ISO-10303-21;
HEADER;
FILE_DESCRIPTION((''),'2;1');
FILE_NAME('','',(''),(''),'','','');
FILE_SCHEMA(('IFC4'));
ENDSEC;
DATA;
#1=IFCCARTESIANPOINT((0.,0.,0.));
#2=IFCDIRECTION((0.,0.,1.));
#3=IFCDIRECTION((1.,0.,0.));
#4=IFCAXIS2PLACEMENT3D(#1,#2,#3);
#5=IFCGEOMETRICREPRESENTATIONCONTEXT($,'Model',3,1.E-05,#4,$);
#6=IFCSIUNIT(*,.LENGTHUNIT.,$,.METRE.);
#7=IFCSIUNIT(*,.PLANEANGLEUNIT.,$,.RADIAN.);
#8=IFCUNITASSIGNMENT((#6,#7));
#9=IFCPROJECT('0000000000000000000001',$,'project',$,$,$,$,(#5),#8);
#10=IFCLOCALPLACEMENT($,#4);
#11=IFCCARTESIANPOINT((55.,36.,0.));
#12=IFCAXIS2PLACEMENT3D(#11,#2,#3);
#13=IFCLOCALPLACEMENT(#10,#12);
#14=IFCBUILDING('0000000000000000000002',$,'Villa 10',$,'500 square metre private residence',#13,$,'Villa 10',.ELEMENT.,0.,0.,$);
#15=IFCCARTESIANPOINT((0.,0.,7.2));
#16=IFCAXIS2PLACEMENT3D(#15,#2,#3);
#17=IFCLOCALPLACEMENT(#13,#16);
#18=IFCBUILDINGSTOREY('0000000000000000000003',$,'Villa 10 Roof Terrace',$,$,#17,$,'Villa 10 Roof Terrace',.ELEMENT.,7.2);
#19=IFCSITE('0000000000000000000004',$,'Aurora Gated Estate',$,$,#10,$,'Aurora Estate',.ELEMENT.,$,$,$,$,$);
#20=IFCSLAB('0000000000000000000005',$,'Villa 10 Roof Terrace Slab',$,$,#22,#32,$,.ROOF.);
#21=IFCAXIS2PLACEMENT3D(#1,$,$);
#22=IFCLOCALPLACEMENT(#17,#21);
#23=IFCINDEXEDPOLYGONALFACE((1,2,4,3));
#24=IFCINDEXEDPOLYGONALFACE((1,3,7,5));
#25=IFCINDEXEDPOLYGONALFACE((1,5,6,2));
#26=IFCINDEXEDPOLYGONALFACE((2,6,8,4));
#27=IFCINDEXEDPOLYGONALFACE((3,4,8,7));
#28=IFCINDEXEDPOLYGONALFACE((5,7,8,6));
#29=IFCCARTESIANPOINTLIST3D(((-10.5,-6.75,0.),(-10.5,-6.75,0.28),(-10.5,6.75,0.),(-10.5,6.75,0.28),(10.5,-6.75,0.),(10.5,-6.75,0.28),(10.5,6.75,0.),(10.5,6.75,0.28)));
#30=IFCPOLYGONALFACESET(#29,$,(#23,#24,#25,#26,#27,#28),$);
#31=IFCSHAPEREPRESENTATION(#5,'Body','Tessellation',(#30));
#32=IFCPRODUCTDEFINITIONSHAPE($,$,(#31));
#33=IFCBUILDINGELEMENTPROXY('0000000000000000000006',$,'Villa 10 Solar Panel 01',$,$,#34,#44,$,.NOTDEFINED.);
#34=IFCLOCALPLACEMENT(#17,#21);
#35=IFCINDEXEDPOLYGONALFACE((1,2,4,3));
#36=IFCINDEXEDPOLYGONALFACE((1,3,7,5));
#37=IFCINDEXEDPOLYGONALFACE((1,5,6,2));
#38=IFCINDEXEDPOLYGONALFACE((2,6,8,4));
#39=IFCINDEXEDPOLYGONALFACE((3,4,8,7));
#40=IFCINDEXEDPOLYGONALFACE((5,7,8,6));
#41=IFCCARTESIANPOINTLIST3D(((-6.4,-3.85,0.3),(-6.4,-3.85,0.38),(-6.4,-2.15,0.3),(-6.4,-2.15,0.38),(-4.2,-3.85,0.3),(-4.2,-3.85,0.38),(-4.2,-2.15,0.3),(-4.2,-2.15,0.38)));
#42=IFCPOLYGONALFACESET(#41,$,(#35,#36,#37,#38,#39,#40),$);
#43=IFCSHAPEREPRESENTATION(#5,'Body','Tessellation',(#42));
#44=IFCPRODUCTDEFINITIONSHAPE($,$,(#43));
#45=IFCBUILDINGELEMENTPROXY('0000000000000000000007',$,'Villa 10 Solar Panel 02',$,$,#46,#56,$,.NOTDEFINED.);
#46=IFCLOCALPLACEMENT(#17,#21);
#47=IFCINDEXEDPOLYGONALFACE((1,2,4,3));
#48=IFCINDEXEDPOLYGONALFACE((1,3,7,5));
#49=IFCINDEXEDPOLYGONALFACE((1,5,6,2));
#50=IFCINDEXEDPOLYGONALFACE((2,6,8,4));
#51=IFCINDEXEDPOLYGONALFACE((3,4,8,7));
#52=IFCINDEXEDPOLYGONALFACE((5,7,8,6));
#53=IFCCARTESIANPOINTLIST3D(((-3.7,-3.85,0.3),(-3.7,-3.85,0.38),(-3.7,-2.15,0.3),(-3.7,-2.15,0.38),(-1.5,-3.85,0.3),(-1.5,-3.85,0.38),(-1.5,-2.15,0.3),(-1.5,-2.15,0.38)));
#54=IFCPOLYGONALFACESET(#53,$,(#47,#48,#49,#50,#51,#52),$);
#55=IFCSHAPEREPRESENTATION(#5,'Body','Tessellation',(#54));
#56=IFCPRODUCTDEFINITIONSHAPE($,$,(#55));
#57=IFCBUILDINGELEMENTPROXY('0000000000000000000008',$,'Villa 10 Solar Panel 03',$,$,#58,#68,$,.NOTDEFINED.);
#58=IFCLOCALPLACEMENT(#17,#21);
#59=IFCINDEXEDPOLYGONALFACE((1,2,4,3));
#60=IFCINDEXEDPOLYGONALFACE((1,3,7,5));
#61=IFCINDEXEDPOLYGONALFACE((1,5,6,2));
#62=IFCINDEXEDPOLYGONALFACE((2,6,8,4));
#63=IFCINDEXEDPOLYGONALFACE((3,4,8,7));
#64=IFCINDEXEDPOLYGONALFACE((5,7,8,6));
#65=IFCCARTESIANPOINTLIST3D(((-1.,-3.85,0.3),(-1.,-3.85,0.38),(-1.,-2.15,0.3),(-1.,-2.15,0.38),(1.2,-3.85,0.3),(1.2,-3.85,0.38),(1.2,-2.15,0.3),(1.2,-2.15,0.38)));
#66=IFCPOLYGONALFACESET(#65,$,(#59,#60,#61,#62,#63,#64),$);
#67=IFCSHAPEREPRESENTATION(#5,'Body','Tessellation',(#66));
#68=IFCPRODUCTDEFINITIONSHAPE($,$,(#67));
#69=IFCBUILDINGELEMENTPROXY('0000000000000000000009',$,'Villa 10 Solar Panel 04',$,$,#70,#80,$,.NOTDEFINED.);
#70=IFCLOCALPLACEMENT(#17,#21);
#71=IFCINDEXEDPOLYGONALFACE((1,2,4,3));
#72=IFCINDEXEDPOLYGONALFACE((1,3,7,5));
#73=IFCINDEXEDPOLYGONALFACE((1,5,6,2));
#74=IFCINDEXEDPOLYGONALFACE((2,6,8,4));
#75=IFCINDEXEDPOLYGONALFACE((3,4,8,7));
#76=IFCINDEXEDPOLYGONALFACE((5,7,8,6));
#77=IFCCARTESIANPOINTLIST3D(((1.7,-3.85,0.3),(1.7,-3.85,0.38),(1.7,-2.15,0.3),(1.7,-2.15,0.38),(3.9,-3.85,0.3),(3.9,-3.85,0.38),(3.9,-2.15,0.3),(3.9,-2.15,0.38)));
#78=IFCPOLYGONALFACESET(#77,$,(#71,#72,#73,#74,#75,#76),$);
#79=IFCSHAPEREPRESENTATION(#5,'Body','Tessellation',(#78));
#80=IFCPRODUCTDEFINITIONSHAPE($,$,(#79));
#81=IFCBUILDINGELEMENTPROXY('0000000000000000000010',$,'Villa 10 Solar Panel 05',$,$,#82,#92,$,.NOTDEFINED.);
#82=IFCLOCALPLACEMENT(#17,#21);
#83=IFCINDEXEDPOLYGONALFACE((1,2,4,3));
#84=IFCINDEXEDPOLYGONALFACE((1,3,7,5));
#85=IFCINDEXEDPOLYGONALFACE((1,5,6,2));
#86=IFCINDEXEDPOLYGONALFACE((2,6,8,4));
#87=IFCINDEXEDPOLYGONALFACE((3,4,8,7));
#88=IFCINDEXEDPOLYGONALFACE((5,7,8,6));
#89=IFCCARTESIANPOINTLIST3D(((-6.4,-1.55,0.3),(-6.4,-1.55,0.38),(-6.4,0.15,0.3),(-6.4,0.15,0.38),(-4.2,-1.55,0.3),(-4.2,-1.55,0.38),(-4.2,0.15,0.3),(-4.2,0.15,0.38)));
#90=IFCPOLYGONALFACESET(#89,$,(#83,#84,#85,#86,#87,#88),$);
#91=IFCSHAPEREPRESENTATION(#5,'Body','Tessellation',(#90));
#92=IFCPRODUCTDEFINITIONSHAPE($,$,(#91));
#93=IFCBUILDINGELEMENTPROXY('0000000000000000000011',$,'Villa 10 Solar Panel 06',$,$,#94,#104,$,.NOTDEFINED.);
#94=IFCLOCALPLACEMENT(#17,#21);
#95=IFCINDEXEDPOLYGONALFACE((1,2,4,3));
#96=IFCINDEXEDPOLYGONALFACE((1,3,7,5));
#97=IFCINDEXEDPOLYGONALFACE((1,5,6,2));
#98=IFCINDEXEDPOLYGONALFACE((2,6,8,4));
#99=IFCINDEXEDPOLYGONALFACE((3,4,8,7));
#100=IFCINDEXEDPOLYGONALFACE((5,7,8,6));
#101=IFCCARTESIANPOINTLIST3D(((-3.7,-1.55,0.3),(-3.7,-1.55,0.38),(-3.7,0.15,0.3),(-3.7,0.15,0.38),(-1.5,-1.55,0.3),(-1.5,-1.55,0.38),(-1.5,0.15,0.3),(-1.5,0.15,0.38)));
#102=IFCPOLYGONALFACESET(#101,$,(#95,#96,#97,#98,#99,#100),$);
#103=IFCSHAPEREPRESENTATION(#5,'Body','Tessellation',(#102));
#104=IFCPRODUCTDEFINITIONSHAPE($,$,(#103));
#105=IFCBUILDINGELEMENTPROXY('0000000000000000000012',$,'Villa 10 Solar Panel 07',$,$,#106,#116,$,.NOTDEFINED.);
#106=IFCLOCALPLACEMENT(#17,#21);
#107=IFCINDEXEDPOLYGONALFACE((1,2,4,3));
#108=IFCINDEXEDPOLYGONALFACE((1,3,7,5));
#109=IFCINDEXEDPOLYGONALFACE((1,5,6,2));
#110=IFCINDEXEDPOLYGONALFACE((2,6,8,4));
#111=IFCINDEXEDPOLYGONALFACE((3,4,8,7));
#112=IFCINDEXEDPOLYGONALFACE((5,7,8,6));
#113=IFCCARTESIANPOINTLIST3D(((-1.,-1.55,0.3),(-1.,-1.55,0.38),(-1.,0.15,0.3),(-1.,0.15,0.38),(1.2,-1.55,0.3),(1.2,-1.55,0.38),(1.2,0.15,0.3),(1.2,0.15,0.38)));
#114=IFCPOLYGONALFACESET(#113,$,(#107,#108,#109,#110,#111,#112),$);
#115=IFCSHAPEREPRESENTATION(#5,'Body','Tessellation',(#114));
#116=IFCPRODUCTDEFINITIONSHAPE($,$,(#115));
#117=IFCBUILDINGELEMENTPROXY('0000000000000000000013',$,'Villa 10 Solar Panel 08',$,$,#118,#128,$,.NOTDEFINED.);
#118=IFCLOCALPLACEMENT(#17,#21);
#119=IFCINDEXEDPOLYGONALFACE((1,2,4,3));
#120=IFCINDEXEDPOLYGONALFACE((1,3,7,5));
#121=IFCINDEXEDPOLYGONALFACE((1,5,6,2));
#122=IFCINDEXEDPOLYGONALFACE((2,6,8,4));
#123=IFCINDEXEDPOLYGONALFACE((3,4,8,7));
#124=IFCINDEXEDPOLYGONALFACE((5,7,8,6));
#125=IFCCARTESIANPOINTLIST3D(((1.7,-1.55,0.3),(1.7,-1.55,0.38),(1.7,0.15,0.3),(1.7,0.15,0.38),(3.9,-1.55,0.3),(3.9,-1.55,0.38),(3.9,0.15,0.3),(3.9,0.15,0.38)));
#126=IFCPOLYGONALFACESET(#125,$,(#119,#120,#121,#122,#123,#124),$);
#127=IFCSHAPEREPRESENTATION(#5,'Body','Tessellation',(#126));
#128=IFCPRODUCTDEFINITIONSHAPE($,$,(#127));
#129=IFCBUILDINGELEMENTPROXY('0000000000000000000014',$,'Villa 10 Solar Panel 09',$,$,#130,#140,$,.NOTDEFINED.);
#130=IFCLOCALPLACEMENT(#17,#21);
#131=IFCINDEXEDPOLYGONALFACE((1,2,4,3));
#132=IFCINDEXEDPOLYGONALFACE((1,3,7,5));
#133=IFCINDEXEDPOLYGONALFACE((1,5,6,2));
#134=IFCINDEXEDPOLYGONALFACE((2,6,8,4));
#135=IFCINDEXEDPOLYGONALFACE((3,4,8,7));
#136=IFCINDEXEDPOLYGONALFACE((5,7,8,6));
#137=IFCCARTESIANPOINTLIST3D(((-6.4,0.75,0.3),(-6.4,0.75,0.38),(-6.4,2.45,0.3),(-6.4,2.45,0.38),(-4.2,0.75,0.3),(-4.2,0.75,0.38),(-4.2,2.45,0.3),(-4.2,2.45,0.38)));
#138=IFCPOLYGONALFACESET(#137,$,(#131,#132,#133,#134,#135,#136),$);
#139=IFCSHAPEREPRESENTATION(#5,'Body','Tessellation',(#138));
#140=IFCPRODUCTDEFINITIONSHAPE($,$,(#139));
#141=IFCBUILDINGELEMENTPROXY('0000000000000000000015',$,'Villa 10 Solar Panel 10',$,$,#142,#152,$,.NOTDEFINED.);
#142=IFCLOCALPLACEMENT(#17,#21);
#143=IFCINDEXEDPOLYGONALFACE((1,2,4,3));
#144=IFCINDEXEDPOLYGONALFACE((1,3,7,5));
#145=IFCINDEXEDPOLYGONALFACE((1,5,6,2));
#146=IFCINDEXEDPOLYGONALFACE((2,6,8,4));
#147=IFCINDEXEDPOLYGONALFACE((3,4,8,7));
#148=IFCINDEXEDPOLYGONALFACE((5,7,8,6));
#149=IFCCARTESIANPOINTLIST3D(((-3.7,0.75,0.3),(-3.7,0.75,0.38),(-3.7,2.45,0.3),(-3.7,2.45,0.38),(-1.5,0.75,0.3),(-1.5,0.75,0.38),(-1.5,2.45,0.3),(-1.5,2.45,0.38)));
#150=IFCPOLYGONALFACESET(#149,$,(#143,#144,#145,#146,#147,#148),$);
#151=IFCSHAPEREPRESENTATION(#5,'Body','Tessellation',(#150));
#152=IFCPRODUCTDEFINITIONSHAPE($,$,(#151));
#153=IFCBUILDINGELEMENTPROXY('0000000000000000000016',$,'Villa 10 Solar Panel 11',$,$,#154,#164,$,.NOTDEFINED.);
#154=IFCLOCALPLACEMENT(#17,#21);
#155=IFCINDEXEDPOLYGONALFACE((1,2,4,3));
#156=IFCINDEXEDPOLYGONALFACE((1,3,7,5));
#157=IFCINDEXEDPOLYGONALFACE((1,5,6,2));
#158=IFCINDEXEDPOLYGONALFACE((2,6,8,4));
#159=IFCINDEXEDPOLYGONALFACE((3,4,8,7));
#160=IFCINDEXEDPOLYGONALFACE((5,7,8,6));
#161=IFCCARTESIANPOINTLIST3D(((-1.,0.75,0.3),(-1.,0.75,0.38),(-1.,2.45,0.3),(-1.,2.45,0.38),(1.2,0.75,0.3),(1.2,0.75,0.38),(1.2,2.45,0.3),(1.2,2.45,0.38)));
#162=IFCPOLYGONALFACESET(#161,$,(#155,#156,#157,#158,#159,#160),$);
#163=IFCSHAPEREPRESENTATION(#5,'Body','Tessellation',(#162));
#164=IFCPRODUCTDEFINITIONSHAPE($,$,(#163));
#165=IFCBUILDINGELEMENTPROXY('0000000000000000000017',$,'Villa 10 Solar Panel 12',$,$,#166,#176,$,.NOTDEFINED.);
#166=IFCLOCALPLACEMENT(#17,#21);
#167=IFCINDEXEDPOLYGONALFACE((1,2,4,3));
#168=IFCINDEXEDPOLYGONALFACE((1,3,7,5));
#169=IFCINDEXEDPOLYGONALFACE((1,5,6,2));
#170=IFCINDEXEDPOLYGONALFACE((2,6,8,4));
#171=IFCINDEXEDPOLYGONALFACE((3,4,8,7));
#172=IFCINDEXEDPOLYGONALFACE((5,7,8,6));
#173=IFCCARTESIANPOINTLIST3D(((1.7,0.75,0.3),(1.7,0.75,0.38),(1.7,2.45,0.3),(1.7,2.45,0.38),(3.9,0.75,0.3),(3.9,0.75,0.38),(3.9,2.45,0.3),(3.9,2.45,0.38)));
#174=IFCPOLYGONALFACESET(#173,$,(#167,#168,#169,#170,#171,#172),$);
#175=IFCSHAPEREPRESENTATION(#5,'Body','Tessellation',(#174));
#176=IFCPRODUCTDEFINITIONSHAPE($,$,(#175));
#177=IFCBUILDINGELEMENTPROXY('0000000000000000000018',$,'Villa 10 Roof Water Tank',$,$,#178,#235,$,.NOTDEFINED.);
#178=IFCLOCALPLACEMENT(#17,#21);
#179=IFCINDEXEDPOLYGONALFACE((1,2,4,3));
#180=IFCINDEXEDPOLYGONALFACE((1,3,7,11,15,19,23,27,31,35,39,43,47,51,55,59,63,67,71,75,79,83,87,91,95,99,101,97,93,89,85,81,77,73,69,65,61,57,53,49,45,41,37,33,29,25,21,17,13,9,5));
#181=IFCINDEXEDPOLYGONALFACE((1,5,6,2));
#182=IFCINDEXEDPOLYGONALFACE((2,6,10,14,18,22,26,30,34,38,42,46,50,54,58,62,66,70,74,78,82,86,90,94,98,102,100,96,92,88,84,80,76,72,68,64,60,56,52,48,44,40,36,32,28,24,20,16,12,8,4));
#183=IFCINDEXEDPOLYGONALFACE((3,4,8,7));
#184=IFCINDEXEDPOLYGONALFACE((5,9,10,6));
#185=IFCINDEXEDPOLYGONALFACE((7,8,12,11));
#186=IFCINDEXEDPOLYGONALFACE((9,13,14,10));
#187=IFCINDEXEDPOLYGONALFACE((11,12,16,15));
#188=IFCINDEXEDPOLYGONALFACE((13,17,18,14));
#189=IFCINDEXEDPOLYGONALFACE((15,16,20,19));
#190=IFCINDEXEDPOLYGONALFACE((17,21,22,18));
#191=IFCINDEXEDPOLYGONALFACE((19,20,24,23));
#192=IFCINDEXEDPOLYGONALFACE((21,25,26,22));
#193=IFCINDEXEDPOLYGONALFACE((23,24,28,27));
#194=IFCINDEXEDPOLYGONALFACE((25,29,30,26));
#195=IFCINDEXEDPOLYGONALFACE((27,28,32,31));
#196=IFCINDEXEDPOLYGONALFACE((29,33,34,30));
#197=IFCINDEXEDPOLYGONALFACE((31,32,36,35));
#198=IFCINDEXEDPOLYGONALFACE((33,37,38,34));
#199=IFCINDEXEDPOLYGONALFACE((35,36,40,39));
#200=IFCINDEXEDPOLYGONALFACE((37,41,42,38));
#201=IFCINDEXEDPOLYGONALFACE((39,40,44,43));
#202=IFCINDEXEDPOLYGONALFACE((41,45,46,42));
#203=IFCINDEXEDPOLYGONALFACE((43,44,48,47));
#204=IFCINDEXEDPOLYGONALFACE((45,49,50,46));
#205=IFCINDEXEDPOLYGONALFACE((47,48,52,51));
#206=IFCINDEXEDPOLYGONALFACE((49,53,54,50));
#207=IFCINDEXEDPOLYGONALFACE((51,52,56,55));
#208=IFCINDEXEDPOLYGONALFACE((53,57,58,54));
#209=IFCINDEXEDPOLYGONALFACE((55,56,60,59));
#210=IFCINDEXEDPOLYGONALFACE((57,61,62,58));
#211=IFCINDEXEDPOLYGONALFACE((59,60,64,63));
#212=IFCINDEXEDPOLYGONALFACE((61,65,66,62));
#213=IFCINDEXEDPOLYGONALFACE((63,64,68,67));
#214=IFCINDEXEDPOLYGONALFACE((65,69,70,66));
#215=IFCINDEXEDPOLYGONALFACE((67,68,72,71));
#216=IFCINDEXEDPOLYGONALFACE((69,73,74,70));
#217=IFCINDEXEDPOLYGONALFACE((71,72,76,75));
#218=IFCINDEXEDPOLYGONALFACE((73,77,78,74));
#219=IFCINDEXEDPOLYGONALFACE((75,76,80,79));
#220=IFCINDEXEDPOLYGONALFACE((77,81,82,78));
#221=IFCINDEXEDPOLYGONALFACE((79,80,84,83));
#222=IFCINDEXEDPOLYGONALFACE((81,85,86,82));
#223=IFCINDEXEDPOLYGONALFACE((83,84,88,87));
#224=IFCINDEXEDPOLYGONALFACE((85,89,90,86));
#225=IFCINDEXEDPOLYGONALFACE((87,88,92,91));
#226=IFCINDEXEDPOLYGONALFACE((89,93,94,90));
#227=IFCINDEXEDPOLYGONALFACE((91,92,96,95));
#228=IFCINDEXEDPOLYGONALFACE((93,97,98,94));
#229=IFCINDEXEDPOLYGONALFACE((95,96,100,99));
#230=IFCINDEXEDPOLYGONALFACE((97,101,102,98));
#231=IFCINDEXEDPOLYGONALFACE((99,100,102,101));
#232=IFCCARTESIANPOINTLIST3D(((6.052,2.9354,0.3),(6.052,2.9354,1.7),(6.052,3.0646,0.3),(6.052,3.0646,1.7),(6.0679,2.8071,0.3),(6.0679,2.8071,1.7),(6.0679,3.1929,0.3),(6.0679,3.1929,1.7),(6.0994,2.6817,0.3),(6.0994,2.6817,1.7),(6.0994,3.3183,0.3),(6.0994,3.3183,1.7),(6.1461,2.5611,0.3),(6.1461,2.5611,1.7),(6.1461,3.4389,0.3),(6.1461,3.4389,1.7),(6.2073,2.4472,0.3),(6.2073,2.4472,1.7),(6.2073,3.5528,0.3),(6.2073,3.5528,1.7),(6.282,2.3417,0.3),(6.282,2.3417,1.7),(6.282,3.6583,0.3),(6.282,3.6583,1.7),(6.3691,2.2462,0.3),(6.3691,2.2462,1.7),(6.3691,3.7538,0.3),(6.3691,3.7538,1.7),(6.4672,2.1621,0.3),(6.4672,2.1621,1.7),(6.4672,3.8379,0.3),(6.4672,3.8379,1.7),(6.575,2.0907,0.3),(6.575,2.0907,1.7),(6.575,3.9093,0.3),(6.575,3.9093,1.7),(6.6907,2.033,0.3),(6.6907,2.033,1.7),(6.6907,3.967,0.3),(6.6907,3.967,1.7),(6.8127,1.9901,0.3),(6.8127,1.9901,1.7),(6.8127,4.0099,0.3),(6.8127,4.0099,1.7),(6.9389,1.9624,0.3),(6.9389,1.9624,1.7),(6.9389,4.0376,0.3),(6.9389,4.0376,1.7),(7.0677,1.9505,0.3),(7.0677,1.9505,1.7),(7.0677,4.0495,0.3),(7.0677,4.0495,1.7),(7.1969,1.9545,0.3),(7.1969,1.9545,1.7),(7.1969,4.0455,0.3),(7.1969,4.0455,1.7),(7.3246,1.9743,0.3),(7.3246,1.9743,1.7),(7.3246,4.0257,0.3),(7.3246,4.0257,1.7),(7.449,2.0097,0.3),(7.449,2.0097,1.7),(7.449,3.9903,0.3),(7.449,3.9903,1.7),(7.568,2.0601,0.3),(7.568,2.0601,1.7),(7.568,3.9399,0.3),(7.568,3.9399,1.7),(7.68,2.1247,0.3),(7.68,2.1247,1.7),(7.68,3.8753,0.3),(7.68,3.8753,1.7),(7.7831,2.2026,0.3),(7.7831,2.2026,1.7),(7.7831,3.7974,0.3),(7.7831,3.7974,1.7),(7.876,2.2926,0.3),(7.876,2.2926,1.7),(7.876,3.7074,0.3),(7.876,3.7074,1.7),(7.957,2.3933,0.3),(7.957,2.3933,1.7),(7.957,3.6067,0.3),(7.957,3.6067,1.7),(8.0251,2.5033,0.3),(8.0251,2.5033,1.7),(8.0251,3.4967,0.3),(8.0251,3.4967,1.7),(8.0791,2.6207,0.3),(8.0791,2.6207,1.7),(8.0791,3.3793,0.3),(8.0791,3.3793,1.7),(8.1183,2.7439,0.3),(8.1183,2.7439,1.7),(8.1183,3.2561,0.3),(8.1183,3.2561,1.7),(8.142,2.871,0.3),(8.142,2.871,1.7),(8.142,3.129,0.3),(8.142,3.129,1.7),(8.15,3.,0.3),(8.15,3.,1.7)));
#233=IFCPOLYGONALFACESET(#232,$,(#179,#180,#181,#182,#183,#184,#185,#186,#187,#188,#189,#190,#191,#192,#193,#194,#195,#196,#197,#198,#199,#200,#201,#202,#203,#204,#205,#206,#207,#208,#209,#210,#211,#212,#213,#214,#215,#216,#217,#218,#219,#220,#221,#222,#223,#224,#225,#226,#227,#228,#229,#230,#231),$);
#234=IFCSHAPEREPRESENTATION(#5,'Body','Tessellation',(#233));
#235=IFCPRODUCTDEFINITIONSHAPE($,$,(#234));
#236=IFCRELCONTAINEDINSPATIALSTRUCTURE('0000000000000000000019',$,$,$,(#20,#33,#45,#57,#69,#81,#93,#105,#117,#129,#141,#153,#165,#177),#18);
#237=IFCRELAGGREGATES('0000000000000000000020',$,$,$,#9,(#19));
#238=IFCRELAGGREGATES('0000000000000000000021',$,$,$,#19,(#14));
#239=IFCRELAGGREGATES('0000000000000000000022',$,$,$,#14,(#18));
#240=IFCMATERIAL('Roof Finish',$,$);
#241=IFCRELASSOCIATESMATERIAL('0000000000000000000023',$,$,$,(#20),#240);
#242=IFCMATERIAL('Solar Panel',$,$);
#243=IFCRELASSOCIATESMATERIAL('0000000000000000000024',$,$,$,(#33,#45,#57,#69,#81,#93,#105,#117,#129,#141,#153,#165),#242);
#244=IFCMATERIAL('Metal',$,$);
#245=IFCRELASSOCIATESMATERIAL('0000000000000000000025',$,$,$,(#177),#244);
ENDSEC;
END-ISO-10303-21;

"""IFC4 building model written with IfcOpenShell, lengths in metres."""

from ifc_helpers import new_model, si_unit, frame, origin_with_axes, origin_2d_with_axis, place, context, project, spatial, rectangle, circle, extrude, material, element, save


model = new_model("IFC4")

# Units and contexts
model_context = context("Model", 3, precision=1e-05, world=origin_with_axes())
ifc_project = project(units=[si_unit("LENGTHUNIT", "METRE"), si_unit("PLANEANGLEUNIT", "RADIAN")], contexts=[model_context])

# Site, building, storey
site_placement = place(None, origin_with_axes())
site = spatial("IfcSite", under=ifc_project, at=site_placement, Name="Aurora Gated Estate", LongName="Aurora Estate", CompositionType="ELEMENT")
building_placement = place(site_placement, frame((55.0, 36.0, 0.0), z_axis=(0.0, 0.0, 1.0), x_axis=(1.0, 0.0, 0.0)))
building = spatial("IfcBuilding", under=site, at=building_placement, Name="Villa 10", ObjectType="500 square metre private residence", LongName="Villa 10", CompositionType="ELEMENT", ElevationOfRefHeight=0.0, ElevationOfTerrain=0.0)
storey_placement = place(building_placement, frame((0.0, 0.0, 7.2), z_axis=(0.0, 0.0, 1.0), x_axis=(1.0, 0.0, 0.0)))
storey = spatial("IfcBuildingStorey", under=building, at=storey_placement, Name="Villa 10 Roof Terrace", LongName="Villa 10 Roof Terrace", CompositionType="ELEMENT", Elevation=7.2)

# Slab
ifc_material_1 = material(Name="Roof Finish")
slab_placement = place(storey_placement, origin_with_axes())
element("IfcSlab", 1, at=slab_placement, inside=storey, material=ifc_material_1, Name="Villa 10 Roof Terrace Slab", PredefinedType="ROOF", context=model_context, shape_type="SweptSolid", body=[
    extrude(rectangle(XDim=21.0, YDim=13.5, at=origin_2d_with_axis()), origin_with_axes(), (0.0, 0.0, 1.0), 0.28),
])

# Building element proxies
ifc_material_2 = material(Name="Solar Panel")
for number, where, z_axis, x_axis, name in (
    (2, (-5.3, -3.0, 0.3), (0.0, 0.0, 1.0), (1.0, 0.0, 0.0), "Villa 10 Solar Panel 01"),
    (3, (-2.6, -3.0, 0.3), (0.0, 0.0, 1.0), (1.0, 0.0, 0.0), "Villa 10 Solar Panel 02"),
    (4, (0.1, -3.0, 0.3), (0.0, 0.0, 1.0), (1.0, 0.0, 0.0), "Villa 10 Solar Panel 03"),
    (5, (2.8, -3.0, 0.3), (0.0, 0.0, 1.0), (1.0, 0.0, 0.0), "Villa 10 Solar Panel 04"),
    (6, (-5.3, -0.7, 0.3), (0.0, 0.0, 1.0), (1.0, 0.0, 0.0), "Villa 10 Solar Panel 05"),
    (7, (-2.6, -0.7, 0.3), (0.0, 0.0, 1.0), (1.0, 0.0, 0.0), "Villa 10 Solar Panel 06"),
    (8, (0.1, -0.7, 0.3), (0.0, 0.0, 1.0), (1.0, 0.0, 0.0), "Villa 10 Solar Panel 07"),
    (9, (2.8, -0.7, 0.3), (0.0, 0.0, 1.0), (1.0, 0.0, 0.0), "Villa 10 Solar Panel 08"),
    (10, (-5.3, 1.6, 0.3), (0.0, 0.0, 1.0), (1.0, 0.0, 0.0), "Villa 10 Solar Panel 09"),
    (11, (-2.6, 1.6, 0.3), (0.0, 0.0, 1.0), (1.0, 0.0, 0.0), "Villa 10 Solar Panel 10"),
    (12, (0.1, 1.6, 0.3), (0.0, 0.0, 1.0), (1.0, 0.0, 0.0), "Villa 10 Solar Panel 11"),
    (13, (2.8, 1.6, 0.3), (0.0, 0.0, 1.0), (1.0, 0.0, 0.0), "Villa 10 Solar Panel 12"),
):
    element("IfcBuildingElementProxy", number, at=place(storey_placement, frame(where, z_axis=z_axis, x_axis=x_axis)), inside=storey, material=ifc_material_2, Name=name, PredefinedType="NOTDEFINED", context=model_context, shape_type="SweptSolid", body=[
        extrude(rectangle(XDim=2.2, YDim=1.7, at=origin_2d_with_axis()), origin_with_axes(), (0.0, 0.0, 1.0), 0.08),
    ])
ifc_material_3 = material(Name="Metal")
proxy_1_placement = place(storey_placement, frame((7.1, 3.0, 0.3), z_axis=(0.0, 0.0, 1.0), x_axis=(1.0, 0.0, 0.0)))
element("IfcBuildingElementProxy", 14, at=proxy_1_placement, inside=storey, material=ifc_material_3, Name="Villa 10 Roof Water Tank", PredefinedType="NOTDEFINED", context=model_context, shape_type="SweptSolid", body=[
    extrude(circle(Radius=1.05, at=origin_2d_with_axis()), origin_with_axes(), (0.0, 0.0, 1.0), 1.4),
])

save(model, "model.ifc")
